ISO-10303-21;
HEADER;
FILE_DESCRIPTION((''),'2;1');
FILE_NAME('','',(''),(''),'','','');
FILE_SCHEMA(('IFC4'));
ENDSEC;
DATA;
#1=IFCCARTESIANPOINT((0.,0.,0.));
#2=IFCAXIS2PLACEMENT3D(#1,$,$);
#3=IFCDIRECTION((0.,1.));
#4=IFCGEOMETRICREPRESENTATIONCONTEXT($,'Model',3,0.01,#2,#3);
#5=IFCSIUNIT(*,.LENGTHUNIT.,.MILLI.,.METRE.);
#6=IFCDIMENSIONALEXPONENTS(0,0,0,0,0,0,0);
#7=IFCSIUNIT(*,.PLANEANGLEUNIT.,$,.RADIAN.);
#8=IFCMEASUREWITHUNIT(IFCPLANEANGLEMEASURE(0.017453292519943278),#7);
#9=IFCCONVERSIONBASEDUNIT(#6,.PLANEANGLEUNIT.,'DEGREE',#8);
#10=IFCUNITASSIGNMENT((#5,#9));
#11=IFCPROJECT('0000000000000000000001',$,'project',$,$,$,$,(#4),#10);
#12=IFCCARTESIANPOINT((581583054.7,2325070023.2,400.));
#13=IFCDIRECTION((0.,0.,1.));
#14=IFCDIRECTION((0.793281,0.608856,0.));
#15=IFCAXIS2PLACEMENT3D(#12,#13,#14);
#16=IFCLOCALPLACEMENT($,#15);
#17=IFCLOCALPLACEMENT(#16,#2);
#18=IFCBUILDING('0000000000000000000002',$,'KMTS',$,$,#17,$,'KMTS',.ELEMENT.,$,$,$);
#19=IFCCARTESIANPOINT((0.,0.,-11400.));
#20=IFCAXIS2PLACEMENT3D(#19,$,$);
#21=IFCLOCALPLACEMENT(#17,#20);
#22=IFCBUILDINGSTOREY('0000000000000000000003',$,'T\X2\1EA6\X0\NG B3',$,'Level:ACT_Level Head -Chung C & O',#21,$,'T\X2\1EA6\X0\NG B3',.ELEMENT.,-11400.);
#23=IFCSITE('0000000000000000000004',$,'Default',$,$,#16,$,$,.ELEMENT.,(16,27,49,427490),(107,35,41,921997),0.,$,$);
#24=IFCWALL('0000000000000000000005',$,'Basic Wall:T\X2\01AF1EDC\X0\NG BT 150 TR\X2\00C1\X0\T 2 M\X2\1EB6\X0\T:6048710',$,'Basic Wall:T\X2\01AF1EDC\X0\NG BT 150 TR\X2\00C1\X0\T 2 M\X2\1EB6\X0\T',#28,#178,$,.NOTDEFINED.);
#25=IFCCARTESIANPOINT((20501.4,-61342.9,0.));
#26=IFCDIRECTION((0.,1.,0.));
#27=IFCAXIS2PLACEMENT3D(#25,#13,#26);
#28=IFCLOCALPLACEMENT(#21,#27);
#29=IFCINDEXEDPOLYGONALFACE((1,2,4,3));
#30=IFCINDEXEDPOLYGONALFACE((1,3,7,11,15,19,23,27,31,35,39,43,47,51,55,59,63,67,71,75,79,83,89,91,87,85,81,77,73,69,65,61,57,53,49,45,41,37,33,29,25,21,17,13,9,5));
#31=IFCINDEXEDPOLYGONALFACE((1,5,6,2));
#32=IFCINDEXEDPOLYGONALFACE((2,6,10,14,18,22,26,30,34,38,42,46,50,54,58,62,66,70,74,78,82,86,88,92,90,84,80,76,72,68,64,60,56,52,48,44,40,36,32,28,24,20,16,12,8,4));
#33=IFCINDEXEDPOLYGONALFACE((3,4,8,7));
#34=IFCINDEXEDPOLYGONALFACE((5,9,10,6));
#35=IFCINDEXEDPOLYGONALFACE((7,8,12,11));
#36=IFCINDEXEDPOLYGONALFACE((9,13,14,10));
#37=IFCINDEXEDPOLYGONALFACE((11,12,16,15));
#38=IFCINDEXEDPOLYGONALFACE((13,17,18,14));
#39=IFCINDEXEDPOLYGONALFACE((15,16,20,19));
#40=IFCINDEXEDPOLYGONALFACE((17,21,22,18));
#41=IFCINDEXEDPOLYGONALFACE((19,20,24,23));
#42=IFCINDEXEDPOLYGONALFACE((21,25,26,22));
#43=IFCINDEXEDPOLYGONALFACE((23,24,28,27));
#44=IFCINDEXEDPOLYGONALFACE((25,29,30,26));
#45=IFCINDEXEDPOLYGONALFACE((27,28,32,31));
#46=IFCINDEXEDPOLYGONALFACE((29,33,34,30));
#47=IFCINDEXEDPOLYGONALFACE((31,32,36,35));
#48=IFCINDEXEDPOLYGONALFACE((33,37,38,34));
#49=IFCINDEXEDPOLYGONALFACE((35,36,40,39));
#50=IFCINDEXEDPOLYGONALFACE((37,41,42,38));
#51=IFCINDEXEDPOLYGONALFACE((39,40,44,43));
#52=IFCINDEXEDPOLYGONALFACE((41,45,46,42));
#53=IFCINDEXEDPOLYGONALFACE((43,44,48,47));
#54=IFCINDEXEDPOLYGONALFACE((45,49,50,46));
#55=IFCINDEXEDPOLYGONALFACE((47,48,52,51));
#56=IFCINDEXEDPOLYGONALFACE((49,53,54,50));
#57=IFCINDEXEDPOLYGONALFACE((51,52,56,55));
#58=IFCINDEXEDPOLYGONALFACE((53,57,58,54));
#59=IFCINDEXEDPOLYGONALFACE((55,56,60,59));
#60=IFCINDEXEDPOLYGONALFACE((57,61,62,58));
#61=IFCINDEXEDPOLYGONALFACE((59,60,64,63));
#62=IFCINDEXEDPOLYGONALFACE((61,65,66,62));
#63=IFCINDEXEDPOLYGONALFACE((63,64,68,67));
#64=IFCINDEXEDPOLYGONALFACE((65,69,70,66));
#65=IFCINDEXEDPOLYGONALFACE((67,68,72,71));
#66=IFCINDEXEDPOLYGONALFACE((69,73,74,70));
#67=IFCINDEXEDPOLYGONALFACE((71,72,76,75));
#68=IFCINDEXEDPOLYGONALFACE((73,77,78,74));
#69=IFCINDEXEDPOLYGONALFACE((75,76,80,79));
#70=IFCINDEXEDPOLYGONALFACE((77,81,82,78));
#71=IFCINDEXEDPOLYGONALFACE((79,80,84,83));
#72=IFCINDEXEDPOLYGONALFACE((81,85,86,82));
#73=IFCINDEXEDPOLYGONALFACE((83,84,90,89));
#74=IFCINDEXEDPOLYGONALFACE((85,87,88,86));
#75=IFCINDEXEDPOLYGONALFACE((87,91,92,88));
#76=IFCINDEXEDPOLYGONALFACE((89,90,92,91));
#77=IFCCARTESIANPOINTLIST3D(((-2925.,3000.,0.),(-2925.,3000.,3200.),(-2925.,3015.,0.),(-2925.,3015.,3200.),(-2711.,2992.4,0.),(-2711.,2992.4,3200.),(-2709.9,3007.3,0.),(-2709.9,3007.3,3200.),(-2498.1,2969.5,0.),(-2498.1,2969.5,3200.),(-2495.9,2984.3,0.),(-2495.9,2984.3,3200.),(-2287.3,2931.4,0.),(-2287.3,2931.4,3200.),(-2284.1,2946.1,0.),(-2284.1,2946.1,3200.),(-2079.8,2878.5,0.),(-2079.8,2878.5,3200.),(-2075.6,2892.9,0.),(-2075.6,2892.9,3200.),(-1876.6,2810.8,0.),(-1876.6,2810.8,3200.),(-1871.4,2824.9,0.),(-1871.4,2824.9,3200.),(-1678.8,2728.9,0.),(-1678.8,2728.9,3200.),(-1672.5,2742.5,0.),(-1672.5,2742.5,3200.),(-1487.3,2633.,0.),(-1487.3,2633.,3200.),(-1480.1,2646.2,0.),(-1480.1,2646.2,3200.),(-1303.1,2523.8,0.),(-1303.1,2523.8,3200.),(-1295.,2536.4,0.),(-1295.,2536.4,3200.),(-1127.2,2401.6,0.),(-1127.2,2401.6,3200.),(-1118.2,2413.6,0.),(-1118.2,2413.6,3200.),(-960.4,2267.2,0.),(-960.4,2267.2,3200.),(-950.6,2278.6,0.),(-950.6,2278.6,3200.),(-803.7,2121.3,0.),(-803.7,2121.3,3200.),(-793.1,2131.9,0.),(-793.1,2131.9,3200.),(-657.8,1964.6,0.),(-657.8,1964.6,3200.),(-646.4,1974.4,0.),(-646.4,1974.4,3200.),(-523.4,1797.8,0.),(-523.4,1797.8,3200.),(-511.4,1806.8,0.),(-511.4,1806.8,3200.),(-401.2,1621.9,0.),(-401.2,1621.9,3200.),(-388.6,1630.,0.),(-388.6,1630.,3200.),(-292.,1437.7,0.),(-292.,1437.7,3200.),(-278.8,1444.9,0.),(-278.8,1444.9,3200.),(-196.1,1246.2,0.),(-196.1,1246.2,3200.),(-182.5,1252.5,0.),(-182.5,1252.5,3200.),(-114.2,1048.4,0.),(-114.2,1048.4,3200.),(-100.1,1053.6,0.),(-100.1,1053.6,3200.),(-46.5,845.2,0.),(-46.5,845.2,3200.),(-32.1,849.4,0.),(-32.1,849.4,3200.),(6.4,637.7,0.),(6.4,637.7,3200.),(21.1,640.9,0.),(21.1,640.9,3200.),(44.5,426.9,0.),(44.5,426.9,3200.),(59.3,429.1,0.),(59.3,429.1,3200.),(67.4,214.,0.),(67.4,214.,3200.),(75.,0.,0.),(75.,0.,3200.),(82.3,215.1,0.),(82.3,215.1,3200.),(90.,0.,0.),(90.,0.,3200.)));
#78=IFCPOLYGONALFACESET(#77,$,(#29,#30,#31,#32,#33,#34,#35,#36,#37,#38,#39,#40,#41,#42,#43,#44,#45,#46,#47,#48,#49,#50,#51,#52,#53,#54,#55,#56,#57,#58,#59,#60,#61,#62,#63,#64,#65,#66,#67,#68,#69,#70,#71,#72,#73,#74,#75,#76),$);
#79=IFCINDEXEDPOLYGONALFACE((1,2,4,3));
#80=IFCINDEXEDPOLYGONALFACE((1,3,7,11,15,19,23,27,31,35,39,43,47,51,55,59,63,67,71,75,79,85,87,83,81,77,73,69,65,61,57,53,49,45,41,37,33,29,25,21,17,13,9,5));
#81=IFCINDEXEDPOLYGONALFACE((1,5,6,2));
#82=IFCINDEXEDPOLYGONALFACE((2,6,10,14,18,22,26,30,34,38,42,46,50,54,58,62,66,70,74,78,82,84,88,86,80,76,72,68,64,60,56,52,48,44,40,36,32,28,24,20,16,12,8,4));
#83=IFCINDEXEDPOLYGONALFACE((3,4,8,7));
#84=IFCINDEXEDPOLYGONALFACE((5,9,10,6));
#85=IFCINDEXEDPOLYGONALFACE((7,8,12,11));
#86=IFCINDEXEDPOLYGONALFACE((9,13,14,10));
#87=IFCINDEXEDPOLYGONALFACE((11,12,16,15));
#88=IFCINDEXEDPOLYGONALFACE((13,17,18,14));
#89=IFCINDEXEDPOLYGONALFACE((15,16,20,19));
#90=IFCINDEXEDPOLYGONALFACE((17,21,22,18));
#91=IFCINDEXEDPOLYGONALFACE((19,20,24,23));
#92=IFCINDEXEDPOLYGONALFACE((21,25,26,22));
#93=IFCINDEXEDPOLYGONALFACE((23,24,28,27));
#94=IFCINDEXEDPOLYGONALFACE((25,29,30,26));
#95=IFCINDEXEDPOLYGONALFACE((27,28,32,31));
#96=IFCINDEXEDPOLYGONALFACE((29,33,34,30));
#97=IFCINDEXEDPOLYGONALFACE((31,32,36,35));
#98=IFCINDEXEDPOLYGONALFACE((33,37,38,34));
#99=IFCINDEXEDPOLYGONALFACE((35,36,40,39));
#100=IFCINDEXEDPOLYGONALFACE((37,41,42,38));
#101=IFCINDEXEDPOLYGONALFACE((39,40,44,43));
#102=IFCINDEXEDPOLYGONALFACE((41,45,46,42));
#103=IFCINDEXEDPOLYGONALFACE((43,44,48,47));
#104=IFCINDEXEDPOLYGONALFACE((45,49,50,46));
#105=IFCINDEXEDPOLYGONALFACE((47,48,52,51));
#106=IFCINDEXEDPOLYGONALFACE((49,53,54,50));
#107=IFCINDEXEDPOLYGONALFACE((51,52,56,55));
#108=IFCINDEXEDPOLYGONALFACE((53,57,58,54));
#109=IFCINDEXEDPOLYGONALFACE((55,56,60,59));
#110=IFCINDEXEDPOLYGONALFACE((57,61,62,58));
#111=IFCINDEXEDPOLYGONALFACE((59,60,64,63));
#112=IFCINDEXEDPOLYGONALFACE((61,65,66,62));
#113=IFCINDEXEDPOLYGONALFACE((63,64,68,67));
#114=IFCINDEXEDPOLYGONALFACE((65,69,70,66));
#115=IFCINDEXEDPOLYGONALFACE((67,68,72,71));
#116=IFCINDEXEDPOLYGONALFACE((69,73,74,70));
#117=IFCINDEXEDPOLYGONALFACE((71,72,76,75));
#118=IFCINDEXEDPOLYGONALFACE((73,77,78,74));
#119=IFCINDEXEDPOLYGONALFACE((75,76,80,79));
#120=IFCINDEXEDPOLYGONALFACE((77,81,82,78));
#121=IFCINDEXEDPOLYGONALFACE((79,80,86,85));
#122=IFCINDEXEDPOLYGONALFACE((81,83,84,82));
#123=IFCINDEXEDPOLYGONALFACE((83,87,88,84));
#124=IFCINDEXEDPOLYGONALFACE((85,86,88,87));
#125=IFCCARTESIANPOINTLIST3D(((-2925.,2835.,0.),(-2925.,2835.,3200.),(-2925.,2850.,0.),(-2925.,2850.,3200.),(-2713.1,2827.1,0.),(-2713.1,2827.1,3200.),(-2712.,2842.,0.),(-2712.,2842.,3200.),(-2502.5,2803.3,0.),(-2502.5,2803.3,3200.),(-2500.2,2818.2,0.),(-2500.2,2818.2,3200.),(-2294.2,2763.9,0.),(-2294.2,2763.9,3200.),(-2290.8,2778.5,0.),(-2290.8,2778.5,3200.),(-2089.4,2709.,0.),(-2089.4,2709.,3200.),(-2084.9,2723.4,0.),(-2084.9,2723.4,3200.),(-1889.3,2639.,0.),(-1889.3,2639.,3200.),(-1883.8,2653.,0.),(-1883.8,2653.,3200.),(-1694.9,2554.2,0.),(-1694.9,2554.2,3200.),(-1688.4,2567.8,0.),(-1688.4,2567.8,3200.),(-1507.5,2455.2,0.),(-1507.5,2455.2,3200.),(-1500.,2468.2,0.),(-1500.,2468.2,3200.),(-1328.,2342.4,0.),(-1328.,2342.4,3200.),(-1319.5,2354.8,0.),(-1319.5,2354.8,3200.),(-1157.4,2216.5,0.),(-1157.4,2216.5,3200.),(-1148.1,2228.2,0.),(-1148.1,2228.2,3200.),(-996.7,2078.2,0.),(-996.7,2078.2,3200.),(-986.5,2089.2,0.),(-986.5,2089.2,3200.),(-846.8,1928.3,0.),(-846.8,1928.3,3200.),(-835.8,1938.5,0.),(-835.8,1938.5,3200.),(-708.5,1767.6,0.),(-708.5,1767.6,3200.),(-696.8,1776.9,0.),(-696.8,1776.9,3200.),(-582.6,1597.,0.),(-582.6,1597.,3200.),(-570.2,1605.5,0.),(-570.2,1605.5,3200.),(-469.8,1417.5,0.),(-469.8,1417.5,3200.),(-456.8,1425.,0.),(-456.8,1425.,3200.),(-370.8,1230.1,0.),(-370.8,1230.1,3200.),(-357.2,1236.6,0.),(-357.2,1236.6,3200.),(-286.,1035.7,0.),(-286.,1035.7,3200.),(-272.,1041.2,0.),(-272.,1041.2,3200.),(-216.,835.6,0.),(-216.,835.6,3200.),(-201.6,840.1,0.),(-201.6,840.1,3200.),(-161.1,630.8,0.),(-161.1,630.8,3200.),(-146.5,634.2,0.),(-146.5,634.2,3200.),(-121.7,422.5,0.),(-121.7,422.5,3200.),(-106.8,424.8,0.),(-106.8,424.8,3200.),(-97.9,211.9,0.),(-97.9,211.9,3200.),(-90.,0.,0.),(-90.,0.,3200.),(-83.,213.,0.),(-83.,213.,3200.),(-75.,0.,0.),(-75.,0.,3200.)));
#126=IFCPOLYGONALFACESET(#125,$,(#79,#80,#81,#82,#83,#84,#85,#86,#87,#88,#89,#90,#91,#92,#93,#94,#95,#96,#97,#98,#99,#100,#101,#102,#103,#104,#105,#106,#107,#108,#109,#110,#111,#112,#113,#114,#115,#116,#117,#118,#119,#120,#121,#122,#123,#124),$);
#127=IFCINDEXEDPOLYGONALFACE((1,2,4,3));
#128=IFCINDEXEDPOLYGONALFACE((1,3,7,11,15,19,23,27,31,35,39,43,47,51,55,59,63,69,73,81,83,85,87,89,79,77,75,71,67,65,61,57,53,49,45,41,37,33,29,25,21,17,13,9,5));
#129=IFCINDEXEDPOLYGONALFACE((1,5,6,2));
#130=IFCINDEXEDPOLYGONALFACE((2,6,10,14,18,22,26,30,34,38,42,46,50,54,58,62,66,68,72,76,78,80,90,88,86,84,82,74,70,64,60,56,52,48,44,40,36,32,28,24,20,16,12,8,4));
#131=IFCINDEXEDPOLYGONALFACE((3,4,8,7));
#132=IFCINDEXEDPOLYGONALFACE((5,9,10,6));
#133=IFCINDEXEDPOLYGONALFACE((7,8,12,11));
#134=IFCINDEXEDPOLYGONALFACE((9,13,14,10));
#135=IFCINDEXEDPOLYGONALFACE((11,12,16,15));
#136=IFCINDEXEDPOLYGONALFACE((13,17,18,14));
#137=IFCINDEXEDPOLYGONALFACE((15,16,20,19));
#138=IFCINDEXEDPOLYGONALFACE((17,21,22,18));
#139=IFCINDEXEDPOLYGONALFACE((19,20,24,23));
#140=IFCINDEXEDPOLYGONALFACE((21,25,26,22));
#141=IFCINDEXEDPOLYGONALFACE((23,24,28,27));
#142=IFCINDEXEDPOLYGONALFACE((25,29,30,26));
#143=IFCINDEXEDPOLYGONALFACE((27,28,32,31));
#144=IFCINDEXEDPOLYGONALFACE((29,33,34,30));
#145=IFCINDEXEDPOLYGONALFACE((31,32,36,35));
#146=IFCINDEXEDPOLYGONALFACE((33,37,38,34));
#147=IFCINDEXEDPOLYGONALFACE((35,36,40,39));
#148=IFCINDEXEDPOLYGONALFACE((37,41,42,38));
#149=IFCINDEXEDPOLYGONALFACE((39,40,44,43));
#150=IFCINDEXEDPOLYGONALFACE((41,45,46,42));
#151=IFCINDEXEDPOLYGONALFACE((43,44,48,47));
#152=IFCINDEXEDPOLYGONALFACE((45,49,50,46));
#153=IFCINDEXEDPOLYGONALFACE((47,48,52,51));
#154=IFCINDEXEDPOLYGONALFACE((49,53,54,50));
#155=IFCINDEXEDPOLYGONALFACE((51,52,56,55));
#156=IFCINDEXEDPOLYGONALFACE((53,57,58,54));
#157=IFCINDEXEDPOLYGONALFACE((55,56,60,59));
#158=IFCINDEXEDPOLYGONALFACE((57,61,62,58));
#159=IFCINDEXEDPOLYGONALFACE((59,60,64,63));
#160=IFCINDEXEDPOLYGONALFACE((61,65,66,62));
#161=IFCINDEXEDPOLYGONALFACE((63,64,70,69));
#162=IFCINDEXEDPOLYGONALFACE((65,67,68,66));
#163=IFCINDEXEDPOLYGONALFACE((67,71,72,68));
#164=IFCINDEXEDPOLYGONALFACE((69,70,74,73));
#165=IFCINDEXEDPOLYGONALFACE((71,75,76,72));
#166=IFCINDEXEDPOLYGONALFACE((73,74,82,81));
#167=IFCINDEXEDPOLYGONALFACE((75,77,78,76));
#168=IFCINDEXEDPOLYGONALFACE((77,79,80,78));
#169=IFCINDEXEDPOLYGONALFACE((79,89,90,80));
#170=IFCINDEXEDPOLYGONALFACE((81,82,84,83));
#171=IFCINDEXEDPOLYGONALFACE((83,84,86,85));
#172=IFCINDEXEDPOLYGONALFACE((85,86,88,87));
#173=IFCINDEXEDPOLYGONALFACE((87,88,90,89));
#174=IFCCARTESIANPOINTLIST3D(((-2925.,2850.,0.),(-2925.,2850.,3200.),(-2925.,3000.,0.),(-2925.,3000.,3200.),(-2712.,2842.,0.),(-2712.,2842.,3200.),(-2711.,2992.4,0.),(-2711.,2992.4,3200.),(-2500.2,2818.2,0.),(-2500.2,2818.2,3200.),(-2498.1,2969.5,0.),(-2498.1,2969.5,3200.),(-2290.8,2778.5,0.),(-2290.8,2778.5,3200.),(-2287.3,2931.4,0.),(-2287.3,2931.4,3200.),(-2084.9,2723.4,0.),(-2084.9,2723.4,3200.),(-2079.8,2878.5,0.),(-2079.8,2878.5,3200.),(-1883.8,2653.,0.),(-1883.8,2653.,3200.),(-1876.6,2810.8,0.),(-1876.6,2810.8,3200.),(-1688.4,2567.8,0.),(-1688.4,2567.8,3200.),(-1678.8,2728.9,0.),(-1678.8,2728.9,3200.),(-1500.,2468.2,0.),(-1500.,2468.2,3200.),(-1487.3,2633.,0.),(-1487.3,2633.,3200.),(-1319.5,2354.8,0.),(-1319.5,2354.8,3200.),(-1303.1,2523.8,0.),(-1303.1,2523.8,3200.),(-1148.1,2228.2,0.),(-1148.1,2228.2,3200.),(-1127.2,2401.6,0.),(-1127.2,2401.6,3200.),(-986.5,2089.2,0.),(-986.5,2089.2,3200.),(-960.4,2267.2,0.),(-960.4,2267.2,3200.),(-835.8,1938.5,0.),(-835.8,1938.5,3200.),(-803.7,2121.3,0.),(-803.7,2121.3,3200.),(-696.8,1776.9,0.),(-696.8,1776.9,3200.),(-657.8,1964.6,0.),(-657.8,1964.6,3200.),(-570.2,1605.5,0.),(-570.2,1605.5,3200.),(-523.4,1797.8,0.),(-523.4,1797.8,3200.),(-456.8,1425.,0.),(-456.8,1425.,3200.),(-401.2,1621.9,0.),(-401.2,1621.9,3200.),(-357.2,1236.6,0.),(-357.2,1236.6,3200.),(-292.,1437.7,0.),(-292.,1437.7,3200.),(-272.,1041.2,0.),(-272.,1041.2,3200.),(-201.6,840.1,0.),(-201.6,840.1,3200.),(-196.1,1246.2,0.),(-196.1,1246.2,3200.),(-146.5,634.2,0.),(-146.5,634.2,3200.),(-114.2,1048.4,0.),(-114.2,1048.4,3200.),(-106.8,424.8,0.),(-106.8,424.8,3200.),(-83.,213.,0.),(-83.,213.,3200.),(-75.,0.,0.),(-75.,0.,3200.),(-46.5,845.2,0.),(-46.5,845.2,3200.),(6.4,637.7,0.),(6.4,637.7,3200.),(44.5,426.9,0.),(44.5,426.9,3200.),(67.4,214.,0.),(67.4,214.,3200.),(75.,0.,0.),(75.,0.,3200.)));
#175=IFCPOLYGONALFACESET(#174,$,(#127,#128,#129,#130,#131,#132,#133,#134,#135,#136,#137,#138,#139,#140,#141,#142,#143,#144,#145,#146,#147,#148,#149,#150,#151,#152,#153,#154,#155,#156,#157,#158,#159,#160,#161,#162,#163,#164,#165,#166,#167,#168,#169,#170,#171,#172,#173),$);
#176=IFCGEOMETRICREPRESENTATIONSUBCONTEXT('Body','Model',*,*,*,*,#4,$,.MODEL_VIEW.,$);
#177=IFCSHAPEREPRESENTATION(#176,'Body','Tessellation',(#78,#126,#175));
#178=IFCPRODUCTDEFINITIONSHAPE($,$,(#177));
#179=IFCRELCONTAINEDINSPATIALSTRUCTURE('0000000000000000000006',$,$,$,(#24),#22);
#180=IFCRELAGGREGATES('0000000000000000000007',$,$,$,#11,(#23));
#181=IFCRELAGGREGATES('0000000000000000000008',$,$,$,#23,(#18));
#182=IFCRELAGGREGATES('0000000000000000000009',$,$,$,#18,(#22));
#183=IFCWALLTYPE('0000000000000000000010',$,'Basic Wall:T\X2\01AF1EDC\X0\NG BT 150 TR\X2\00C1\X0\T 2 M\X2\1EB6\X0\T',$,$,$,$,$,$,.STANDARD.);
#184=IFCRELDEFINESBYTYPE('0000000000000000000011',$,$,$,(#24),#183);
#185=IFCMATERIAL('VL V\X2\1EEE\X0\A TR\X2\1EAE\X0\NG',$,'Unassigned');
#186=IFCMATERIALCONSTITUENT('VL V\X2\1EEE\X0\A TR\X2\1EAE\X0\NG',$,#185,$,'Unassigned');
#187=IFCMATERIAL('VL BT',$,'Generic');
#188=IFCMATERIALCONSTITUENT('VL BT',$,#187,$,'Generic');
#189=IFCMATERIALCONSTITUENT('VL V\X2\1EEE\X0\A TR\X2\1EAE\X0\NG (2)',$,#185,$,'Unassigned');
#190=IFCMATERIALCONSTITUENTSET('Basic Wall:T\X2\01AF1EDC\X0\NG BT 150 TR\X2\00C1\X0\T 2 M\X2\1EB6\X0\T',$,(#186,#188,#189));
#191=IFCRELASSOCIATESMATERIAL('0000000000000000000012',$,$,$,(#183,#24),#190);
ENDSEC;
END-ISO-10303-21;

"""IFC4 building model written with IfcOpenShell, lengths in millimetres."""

from ifc_helpers import new_model, entity, si_unit, converted_unit, direction, frame, origin, place, context, subcontext, project, spatial, line, arc, indexed_curve, outline, extrude, material, constituent, constituent_set, type_object, element, save


model = new_model("IFC4")

# Units and contexts
model_context = context("Model", 3, precision=0.01, world=origin(), true_north=direction((0.0, 1.0)))
body_context = subcontext(model_context, "Body", "Model", "MODEL_VIEW")
ifc_project = project(units=[si_unit("LENGTHUNIT", "METRE", prefix="MILLI"), converted_unit("PLANEANGLEUNIT", "DEGREE", entity("IfcPlaneAngleMeasure", 0.017453292519943278), si_unit("PLANEANGLEUNIT", "RADIAN"), dimensions=[0, 0, 0, 0, 0, 0, 0])], contexts=[model_context])

# Site, building, storey
site_placement = place(None, frame((581583054.7, 2325070023.2, 400.0), z_axis=(0.0, 0.0, 1.0), x_axis=(0.793281, 0.608856, 0.0)))
site = spatial("IfcSite", under=ifc_project, at=site_placement, Name="Default", CompositionType="ELEMENT", RefLatitude=(16, 27, 49, 427490), RefLongitude=(107, 35, 41, 921997), RefElevation=0.0)
building_placement = place(site_placement, origin())
building = spatial("IfcBuilding", under=site, at=building_placement, Name="KMTS", LongName="KMTS", CompositionType="ELEMENT")
storey_placement = place(building_placement, frame((0.0, 0.0, -11400.0)))
storey = spatial("IfcBuildingStorey", under=building, at=storey_placement, Name="TẦNG B3", ObjectType="Level:ACT_Level Head -Chung C & O", LongName="TẦNG B3", CompositionType="ELEMENT", Elevation=-11400.0)

# Shared definitions
ifc_material_1 = material(Name="VL VỮA TRẮNG", Category="Unassigned")
ifc_constituent_1 = constituent(ifc_material_1, Name="VL VỮA TRẮNG", Category="Unassigned")
ifc_material_2 = material(Name="VL BT", Category="Generic")
ifc_constituent_2 = constituent(ifc_material_2, Name="VL BT", Category="Generic")
ifc_constituent_3 = constituent(ifc_material_1, Name="VL VỮA TRẮNG (2)", Category="Unassigned")
ifc_constituent_set_1 = constituent_set(constituents=[ifc_constituent_1, ifc_constituent_2, ifc_constituent_3], Name="Basic Wall:TƯỜNG BT 150 TRÁT 2 MẶT")
wall_type_1 = type_object("IfcWallType", Name="Basic Wall:TƯỜNG BT 150 TRÁT 2 MẶT", PredefinedType="STANDARD", material=ifc_constituent_set_1)

# Wall
wall_1_placement = place(storey_placement, frame((20501.4, -61342.9, 0.0), z_axis=(0.0, 0.0, 1.0), x_axis=(0.0, 1.0, 0.0)))
element("IfcWall", 1, at=wall_1_placement, inside=storey, type_object=wall_type_1, material=ifc_constituent_set_1, Name="Basic Wall:TƯỜNG BT 150 TRÁT 2 MẶT:6048710", ObjectType="Basic Wall:TƯỜNG BT 150 TRÁT 2 MẶT", PredefinedType="NOTDEFINED", context=body_context, shape_type="SweptSolid", body=[
    extrude(outline(indexed_curve([(-1511.3, -1503.7), (-1496.3, -1503.8), (-617.6, 617.6), (1503.7, 1496.3), (1503.8, 1511.3), (-628.2, 628.2)], segments=[line(1, 2), arc(2, 3, 4), line(4, 5), arc(5, 6, 1)], self_intersect=False)), frame((-1421.3, 1503.8, 0.0), z_axis=(0.0, 0.0, 1.0), x_axis=(0.0, -1.0, 0.0)), (0.0, 0.0, 1.0), 3200.0),
    extrude(outline(indexed_curve([(1413.8, 1421.2), (583.4, -583.4), (-1421.3, -1413.7), (-1421.3, -1428.7), (594.0, -594.0), (1428.8, 1421.2)], segments=[arc(1, 2, 3), line(3, 4), arc(4, 5, 6), line(6, 1)], self_intersect=False)), frame((-1503.8, 1421.3, 0.0), z_axis=(0.0, 0.0, -1.0), x_axis=(1.0, 0.0, 0.0)), (0.0, 0.0, -1.0), 3200.0),
    extrude(outline(indexed_curve([(-1476.9, -1372.2), (-1478.4, -1522.2), (651.9, -665.6), (1552.7, 1446.4), (1402.7, 1448.0), (547.0, -558.5)], segments=[line(1, 2), arc(2, 3, 4), line(4, 5), arc(5, 6, 1)], self_intersect=False)), frame((-1462.5, 1462.5, 0.0), z_axis=(0.0, 0.0, -1.0), x_axis=(0.999946, -0.010416, 0.0)), (0.0, 0.0, -1.0), 3200.0),
])

save(model, "model.ifc")
